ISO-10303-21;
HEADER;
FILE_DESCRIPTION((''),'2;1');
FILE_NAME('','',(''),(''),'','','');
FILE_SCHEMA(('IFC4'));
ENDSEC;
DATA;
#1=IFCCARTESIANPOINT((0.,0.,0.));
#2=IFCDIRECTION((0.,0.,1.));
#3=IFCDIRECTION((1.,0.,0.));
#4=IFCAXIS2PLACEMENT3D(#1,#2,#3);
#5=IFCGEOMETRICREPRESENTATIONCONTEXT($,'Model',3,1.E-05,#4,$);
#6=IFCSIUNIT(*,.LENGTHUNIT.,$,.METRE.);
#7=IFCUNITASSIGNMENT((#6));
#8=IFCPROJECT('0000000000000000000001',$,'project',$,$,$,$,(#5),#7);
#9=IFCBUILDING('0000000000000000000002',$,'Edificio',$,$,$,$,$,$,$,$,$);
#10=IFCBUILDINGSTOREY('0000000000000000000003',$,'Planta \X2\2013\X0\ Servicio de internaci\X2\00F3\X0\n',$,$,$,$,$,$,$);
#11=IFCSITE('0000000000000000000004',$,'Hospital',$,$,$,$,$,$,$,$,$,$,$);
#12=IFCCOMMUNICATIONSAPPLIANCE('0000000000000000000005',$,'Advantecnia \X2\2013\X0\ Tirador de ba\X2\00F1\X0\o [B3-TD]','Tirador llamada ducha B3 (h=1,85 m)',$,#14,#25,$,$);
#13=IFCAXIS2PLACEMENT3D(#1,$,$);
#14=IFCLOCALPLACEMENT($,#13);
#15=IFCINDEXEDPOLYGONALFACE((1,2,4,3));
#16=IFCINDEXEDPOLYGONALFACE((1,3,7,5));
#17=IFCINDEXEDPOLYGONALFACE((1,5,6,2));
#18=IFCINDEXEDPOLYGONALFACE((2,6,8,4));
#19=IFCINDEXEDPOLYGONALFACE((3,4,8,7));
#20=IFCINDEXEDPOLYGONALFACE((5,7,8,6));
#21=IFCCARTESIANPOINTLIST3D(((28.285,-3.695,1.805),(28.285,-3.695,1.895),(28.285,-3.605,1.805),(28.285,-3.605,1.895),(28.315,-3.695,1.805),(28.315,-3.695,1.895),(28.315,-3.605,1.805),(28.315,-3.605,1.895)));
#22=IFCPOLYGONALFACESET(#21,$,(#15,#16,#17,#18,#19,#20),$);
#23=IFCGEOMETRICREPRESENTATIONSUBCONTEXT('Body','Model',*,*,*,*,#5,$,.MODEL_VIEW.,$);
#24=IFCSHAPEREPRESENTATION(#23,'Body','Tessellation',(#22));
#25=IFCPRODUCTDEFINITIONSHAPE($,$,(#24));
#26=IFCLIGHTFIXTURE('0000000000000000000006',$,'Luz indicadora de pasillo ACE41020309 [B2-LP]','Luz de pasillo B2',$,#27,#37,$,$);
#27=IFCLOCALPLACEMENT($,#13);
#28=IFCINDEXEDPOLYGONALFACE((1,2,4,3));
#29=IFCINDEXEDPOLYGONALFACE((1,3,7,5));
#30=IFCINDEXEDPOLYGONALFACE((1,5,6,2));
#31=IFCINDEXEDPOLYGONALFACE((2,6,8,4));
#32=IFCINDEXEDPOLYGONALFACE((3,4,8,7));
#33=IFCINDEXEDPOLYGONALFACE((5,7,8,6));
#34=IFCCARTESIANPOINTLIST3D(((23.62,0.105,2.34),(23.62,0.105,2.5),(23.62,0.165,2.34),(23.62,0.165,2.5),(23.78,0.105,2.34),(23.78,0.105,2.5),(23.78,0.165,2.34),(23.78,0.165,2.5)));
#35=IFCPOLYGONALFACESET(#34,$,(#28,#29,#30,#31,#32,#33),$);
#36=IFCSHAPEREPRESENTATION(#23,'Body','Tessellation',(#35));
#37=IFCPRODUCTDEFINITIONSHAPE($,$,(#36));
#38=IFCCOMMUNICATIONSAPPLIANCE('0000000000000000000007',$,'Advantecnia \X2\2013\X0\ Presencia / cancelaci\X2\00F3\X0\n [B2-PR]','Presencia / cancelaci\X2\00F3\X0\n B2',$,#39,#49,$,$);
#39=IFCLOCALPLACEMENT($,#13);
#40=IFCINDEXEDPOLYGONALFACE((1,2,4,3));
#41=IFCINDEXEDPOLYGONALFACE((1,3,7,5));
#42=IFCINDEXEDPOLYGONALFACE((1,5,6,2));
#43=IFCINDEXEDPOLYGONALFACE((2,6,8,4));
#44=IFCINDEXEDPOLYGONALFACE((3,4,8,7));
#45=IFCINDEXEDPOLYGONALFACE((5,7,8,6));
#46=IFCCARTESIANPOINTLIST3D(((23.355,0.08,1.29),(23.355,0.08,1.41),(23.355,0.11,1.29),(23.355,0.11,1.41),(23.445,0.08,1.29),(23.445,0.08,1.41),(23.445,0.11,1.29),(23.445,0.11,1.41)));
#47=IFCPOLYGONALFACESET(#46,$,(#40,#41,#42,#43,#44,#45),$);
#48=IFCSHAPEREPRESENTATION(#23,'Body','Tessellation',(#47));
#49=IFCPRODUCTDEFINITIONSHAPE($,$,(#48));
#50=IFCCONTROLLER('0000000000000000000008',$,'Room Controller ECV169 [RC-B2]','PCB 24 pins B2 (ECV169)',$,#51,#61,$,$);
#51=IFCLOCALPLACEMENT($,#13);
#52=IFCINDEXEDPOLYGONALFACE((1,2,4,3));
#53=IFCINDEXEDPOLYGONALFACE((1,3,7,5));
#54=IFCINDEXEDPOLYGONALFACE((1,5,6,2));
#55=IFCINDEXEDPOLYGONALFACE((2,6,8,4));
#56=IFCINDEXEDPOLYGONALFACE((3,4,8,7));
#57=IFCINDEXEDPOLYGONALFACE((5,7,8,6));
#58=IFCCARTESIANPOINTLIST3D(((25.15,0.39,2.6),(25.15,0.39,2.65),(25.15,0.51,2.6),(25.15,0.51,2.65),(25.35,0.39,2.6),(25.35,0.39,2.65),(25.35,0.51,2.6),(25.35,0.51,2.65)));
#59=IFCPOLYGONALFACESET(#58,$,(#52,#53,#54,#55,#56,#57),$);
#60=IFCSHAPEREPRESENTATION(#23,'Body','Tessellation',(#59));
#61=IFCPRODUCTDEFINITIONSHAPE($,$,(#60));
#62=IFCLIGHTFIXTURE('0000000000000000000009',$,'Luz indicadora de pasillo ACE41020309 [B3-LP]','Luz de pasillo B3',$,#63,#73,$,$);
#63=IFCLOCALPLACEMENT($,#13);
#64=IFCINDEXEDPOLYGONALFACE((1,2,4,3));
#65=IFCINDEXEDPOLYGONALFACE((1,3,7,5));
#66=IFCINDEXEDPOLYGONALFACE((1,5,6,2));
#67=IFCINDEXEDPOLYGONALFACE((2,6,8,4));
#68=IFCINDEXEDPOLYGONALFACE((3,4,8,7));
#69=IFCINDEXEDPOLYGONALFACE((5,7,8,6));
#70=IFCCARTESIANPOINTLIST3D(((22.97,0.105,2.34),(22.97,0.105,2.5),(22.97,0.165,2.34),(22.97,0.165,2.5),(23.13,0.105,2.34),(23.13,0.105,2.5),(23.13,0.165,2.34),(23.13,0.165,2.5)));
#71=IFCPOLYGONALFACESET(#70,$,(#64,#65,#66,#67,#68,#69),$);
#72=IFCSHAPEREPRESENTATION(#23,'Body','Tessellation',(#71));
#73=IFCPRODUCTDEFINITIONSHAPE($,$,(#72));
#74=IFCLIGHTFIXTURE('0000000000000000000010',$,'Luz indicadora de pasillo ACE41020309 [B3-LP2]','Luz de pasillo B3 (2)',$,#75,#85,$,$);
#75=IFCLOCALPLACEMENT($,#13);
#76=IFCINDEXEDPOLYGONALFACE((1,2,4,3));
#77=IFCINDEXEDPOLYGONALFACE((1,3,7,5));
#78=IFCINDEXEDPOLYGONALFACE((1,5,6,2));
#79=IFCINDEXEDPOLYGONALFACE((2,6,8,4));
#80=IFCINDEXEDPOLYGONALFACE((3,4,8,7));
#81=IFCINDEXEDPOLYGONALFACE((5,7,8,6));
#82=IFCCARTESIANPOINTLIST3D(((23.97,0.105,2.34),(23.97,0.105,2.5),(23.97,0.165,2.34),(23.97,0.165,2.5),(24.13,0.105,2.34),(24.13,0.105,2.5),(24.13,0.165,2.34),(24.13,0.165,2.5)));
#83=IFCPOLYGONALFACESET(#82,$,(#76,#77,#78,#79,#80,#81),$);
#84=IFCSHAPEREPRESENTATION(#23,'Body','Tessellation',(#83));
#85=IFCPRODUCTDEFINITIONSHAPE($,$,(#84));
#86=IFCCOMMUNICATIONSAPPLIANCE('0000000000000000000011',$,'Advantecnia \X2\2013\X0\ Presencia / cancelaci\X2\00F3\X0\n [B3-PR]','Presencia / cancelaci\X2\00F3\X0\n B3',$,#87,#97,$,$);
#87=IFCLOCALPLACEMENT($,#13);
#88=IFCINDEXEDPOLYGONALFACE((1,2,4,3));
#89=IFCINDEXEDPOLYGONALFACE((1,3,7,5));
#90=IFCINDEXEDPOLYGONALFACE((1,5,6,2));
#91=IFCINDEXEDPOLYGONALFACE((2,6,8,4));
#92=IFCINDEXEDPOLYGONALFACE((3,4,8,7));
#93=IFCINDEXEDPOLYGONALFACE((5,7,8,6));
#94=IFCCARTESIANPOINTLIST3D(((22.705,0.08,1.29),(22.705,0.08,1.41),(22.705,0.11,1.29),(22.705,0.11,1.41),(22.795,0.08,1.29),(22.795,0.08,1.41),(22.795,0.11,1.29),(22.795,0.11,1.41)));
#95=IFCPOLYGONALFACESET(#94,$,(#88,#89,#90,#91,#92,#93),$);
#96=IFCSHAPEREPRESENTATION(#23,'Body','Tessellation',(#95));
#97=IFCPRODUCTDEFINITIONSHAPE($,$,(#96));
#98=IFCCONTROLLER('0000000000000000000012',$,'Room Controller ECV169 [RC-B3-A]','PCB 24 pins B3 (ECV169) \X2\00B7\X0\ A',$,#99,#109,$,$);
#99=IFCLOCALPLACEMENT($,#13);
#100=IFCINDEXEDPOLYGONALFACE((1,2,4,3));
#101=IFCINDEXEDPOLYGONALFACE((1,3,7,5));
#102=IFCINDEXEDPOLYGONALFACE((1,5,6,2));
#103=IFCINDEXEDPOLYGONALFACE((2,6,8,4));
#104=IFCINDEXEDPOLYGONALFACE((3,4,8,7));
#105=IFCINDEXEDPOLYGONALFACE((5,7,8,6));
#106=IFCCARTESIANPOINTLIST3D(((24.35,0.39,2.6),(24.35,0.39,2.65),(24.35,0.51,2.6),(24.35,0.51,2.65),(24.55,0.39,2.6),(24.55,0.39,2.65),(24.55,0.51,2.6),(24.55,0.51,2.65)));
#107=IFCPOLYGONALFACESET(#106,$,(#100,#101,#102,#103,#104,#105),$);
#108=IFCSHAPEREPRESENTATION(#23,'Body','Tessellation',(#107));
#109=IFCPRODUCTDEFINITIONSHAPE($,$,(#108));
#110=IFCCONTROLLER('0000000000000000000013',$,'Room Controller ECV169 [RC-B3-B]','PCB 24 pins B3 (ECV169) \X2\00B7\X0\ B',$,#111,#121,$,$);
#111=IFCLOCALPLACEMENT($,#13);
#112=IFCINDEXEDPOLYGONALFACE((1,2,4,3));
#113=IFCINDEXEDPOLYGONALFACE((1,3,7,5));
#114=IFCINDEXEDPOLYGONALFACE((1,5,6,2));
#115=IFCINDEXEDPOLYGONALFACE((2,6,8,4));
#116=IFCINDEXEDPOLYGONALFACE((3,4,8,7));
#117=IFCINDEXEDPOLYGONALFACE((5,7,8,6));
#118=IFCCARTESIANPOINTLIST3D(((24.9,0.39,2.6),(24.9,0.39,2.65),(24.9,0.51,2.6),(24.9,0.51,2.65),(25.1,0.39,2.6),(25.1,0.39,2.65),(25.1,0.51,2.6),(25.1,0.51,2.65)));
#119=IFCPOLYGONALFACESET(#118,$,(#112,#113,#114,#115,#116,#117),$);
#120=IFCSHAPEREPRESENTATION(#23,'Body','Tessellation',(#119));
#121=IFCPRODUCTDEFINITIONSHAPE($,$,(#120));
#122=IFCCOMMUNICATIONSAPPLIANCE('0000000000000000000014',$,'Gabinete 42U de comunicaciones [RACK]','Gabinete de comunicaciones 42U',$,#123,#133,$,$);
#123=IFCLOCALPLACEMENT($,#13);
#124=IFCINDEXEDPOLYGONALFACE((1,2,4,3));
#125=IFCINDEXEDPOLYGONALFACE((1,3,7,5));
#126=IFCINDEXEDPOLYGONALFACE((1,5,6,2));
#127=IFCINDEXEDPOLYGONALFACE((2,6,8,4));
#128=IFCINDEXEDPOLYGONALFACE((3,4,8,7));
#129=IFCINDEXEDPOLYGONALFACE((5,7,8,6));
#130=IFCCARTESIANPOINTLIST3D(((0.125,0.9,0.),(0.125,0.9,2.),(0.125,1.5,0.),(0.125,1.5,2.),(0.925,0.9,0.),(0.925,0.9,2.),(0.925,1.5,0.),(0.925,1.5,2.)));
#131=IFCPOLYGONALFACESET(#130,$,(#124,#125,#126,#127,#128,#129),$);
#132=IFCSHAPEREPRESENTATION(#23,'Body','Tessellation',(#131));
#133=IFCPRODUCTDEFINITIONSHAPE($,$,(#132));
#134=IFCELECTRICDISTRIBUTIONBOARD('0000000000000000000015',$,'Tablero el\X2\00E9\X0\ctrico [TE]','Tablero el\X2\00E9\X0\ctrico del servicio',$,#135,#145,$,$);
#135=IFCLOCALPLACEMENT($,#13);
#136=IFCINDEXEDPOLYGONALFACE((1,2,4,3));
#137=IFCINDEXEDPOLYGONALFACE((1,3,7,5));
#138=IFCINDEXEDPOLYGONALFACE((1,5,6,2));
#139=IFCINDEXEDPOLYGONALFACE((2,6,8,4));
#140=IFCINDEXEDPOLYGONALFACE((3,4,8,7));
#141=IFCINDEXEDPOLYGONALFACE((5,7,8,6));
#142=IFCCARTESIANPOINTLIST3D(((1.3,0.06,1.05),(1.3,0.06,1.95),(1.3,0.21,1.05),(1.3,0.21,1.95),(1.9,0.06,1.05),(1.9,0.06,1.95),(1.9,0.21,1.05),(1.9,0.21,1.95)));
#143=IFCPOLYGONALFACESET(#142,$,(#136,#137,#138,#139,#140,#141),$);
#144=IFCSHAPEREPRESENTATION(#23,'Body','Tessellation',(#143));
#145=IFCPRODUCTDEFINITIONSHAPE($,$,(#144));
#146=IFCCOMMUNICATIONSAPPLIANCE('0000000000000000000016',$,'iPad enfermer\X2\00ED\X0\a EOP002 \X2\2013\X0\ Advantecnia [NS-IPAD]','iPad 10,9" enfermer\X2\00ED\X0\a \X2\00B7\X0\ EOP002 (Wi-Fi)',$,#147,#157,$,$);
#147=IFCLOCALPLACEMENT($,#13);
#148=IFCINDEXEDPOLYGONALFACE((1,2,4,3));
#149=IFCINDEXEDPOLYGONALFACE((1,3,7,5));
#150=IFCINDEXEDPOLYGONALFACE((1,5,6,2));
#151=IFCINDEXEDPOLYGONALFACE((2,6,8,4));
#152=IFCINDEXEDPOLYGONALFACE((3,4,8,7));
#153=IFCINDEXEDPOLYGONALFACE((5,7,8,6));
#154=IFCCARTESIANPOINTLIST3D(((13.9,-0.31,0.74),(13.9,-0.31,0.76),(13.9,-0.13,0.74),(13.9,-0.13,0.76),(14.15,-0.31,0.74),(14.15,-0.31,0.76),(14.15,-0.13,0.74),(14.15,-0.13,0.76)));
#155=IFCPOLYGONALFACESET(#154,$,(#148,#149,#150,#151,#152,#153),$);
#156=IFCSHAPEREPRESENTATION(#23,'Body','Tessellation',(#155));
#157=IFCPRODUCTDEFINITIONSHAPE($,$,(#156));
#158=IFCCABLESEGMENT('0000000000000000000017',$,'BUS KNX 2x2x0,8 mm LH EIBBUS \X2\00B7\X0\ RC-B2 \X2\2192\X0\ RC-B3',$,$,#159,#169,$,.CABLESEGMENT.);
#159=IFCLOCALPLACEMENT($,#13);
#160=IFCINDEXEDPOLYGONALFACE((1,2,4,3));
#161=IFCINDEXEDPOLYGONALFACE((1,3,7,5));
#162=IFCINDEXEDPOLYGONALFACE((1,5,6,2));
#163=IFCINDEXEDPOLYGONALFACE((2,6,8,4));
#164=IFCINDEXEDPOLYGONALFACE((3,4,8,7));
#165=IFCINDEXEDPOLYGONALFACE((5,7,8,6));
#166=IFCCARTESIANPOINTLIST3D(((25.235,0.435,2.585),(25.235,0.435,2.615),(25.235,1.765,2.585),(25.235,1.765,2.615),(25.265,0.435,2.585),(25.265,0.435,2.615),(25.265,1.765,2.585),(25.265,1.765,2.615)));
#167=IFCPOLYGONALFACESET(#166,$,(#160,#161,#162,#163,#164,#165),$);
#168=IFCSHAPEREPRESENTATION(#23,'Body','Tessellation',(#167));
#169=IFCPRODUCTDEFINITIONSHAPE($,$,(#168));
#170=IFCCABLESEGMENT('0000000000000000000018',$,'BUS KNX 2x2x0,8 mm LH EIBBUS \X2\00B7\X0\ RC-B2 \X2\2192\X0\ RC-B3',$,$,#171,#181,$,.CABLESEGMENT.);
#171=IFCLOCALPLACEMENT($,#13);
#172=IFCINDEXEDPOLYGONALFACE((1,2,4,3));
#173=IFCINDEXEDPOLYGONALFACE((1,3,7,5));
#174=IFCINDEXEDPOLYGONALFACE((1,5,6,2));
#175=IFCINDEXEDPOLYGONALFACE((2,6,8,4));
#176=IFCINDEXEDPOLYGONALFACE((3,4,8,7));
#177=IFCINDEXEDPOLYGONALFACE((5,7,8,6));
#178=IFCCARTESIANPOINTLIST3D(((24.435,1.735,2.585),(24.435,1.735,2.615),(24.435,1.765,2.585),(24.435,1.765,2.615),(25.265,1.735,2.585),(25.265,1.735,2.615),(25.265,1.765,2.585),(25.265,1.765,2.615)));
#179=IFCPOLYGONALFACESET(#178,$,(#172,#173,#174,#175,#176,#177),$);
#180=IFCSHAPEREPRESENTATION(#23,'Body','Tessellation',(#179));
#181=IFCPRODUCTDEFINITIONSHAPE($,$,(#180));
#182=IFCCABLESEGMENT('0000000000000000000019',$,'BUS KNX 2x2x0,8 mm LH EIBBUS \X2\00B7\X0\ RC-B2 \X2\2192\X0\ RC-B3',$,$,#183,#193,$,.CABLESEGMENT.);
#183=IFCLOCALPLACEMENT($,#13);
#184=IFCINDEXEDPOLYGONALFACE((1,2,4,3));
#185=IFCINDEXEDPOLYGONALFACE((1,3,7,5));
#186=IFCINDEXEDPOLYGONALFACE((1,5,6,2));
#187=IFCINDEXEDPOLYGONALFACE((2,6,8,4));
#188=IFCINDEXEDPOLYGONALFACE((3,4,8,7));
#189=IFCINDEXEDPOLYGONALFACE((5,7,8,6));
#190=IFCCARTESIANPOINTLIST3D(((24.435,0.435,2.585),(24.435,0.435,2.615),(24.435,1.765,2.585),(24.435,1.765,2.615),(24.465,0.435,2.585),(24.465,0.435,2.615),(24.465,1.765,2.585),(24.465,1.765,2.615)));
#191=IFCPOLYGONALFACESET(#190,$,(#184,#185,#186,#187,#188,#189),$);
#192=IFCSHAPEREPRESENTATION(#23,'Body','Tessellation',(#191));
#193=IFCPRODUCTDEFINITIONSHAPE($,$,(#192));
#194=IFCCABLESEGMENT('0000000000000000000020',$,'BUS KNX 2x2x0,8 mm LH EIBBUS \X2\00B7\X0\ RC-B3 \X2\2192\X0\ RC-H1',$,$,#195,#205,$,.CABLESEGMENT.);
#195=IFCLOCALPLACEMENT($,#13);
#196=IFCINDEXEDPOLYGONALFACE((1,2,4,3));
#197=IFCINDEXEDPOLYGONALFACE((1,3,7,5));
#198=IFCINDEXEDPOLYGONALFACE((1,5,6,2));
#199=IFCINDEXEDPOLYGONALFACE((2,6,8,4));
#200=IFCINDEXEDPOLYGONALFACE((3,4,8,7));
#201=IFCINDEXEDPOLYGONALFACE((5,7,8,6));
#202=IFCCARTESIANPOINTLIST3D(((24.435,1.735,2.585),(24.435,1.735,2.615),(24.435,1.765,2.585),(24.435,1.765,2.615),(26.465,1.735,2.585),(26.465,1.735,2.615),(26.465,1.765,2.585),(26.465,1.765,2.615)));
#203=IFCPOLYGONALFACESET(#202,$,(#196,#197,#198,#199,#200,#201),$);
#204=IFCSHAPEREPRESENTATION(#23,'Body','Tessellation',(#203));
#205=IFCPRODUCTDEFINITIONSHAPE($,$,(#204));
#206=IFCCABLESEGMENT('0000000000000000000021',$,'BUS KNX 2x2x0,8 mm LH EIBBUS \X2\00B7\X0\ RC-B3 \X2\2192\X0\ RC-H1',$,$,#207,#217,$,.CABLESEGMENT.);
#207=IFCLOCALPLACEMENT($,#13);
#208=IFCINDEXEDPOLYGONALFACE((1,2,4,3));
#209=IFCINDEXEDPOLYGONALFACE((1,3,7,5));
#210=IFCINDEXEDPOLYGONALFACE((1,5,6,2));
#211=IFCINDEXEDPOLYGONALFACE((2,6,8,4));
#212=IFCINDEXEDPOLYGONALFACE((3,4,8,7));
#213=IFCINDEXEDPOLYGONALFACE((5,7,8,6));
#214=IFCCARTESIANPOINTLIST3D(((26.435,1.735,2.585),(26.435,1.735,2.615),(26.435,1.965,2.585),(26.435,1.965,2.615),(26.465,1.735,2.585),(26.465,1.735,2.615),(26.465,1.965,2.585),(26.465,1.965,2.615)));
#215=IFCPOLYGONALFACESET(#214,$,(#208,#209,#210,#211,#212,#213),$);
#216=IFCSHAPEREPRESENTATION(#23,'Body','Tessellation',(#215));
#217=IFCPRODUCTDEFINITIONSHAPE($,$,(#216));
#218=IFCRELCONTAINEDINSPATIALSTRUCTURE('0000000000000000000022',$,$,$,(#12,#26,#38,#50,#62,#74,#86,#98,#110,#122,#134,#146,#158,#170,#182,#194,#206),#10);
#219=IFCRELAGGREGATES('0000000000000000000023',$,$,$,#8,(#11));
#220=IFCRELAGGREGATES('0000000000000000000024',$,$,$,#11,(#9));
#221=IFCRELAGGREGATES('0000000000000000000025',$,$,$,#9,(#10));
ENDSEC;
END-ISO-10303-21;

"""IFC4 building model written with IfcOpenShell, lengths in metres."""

from ifc_helpers import new_model, si_unit, frame, origin_with_axes, context, subcontext, project, spatial, line, indexed_curve, outline, extrude, element, save


model = new_model("IFC4")

# Units and contexts
model_context = context("Model", 3, precision=1e-05, world=origin_with_axes())
body_context = subcontext(model_context, "Body", "Model", "MODEL_VIEW")
ifc_project = project(units=[si_unit("LENGTHUNIT", "METRE")], contexts=[model_context])

# Site, building, storey
site = spatial("IfcSite", under=ifc_project, Name="Hospital")
building = spatial("IfcBuilding", under=site, Name="Edificio")
storey = spatial("IfcBuildingStorey", under=building, Name="Planta – Servicio de internación")

# Communications appliance
element("IfcCommunicationsAppliance", 1, inside=storey, Name="Advantecnia – Tirador de baño [B3-TD]", Description="Tirador llamada ducha B3 (h=1,85 m)", context=body_context, shape_type="SweptSolid", body=[
    extrude(outline(indexed_curve([(0.0, 0.0), (0.03, 0.0), (0.03, 0.09), (0.0, 0.09)], segments=[line(1, 2, 3, 4, 1)])), frame((28.285, -3.695, 1.805), z_axis=(0.0, 0.0, 1.0), x_axis=(1.0, 0.0, 0.0)), (0.0, 0.0, 1.0), 0.09),
])

# Light fixture
element("IfcLightFixture", 2, inside=storey, Name="Luz indicadora de pasillo ACE41020309 [B2-LP]", Description="Luz de pasillo B2", context=body_context, shape_type="SweptSolid", body=[
    extrude(outline(indexed_curve([(0.0, 0.0), (0.16, 0.0), (0.16, 0.06), (0.0, 0.06)], segments=[line(1, 2, 3, 4, 1)])), frame((23.62, 0.105, 2.34), z_axis=(0.0, 0.0, 1.0), x_axis=(1.0, 0.0, 0.0)), (0.0, 0.0, 1.0), 0.16),
])

# Communications appliance
element("IfcCommunicationsAppliance", 3, inside=storey, Name="Advantecnia – Presencia / cancelación [B2-PR]", Description="Presencia / cancelación B2", context=body_context, shape_type="SweptSolid", body=[
    extrude(outline(indexed_curve([(0.0, 0.0), (0.09, 0.0), (0.09, 0.03), (0.0, 0.03)], segments=[line(1, 2, 3, 4, 1)])), frame((23.355, 0.08, 1.29), z_axis=(0.0, 0.0, 1.0), x_axis=(1.0, 0.0, 0.0)), (0.0, 0.0, 1.0), 0.12),
])

# Controller
element("IfcController", 4, inside=storey, Name="Room Controller ECV169 [RC-B2]", Description="PCB 24 pins B2 (ECV169)", context=body_context, shape_type="SweptSolid", body=[
    extrude(outline(indexed_curve([(0.0, 0.0), (0.2, 0.0), (0.2, 0.12), (0.0, 0.12)], segments=[line(1, 2, 3, 4, 1)])), frame((25.15, 0.39, 2.6), z_axis=(0.0, 0.0, 1.0), x_axis=(1.0, 0.0, 0.0)), (0.0, 0.0, 1.0), 0.05),
])

# Light fixtures
element("IfcLightFixture", 5, inside=storey, Name="Luz indicadora de pasillo ACE41020309 [B3-LP]", Description="Luz de pasillo B3", context=body_context, shape_type="SweptSolid", body=[
    extrude(outline(indexed_curve([(0.0, 0.0), (0.16, 0.0), (0.16, 0.06), (0.0, 0.06)], segments=[line(1, 2, 3, 4, 1)])), frame((22.97, 0.105, 2.34), z_axis=(0.0, 0.0, 1.0), x_axis=(1.0, 0.0, 0.0)), (0.0, 0.0, 1.0), 0.16),
])
element("IfcLightFixture", 6, inside=storey, Name="Luz indicadora de pasillo ACE41020309 [B3-LP2]", Description="Luz de pasillo B3 (2)", context=body_context, shape_type="SweptSolid", body=[
    extrude(outline(indexed_curve([(0.0, 0.0), (0.16, 0.0), (0.16, 0.06), (0.0, 0.06)], segments=[line(1, 2, 3, 4, 1)])), frame((23.97, 0.105, 2.34), z_axis=(0.0, 0.0, 1.0), x_axis=(1.0, 0.0, 0.0)), (0.0, 0.0, 1.0), 0.16),
])

# Communications appliance
element("IfcCommunicationsAppliance", 7, inside=storey, Name="Advantecnia – Presencia / cancelación [B3-PR]", Description="Presencia / cancelación B3", context=body_context, shape_type="SweptSolid", body=[
    extrude(outline(indexed_curve([(0.0, 0.0), (0.09, 0.0), (0.09, 0.03), (0.0, 0.03)], segments=[line(1, 2, 3, 4, 1)])), frame((22.705, 0.08, 1.29), z_axis=(0.0, 0.0, 1.0), x_axis=(1.0, 0.0, 0.0)), (0.0, 0.0, 1.0), 0.12),
])

# Controllers
element("IfcController", 8, inside=storey, Name="Room Controller ECV169 [RC-B3-A]", Description="PCB 24 pins B3 (ECV169) · A", context=body_context, shape_type="SweptSolid", body=[
    extrude(outline(indexed_curve([(0.0, 0.0), (0.2, 0.0), (0.2, 0.12), (0.0, 0.12)], segments=[line(1, 2, 3, 4, 1)])), frame((24.35, 0.39, 2.6), z_axis=(0.0, 0.0, 1.0), x_axis=(1.0, 0.0, 0.0)), (0.0, 0.0, 1.0), 0.05),
])
element("IfcController", 9, inside=storey, Name="Room Controller ECV169 [RC-B3-B]", Description="PCB 24 pins B3 (ECV169) · B", context=body_context, shape_type="SweptSolid", body=[
    extrude(outline(indexed_curve([(0.0, 0.0), (0.2, 0.0), (0.2, 0.12), (0.0, 0.12)], segments=[line(1, 2, 3, 4, 1)])), frame((24.9, 0.39, 2.6), z_axis=(0.0, 0.0, 1.0), x_axis=(1.0, 0.0, 0.0)), (0.0, 0.0, 1.0), 0.05),
])

# Communications appliance
element("IfcCommunicationsAppliance", 10, inside=storey, Name="Gabinete 42U de comunicaciones [RACK]", Description="Gabinete de comunicaciones 42U", context=body_context, shape_type="SweptSolid", body=[
    extrude(outline(indexed_curve([(0.0, 0.0), (0.8, 0.0), (0.8, 0.6), (0.0, 0.6)], segments=[line(1, 2, 3, 4, 1)])), frame((0.125, 0.9, 0.0), z_axis=(0.0, 0.0, 1.0), x_axis=(1.0, 0.0, 0.0)), (0.0, 0.0, 1.0), 2.0),
])

# Electric distribution board
element("IfcElectricDistributionBoard", 11, inside=storey, Name="Tablero eléctrico [TE]", Description="Tablero eléctrico del servicio", context=body_context, shape_type="SweptSolid", body=[
    extrude(outline(indexed_curve([(0.0, 0.0), (0.6, 0.0), (0.6, 0.15), (0.0, 0.15)], segments=[line(1, 2, 3, 4, 1)])), frame((1.3, 0.06, 1.05), z_axis=(0.0, 0.0, 1.0), x_axis=(1.0, 0.0, 0.0)), (0.0, 0.0, 1.0), 0.9),
])

# Communications appliance
element("IfcCommunicationsAppliance", 12, inside=storey, Name="iPad enfermería EOP002 – Advantecnia [NS-IPAD]", Description="iPad 10,9\" enfermería · EOP002 (Wi-Fi)", context=body_context, shape_type="SweptSolid", body=[
    extrude(outline(indexed_curve([(0.0, 0.0), (0.25, 0.0), (0.25, 0.18), (0.0, 0.18)], segments=[line(1, 2, 3, 4, 1)])), frame((13.9, -0.31, 0.74), z_axis=(0.0, 0.0, 1.0), x_axis=(1.0, 0.0, 0.0)), (0.0, 0.0, 1.0), 0.02),
])

# Cable segments
element("IfcCableSegment", 13, inside=storey, Name="BUS KNX 2x2x0,8 mm LH EIBBUS · RC-B2 → RC-B3", PredefinedType="CABLESEGMENT", context=body_context, shape_type="SweptSolid", body=[
    extrude(outline(indexed_curve([(0.0, 0.0), (0.03, 0.0), (0.03, 1.33), (0.0, 1.33)], segments=[line(1, 2, 3, 4, 1)])), frame((25.235, 0.435, 2.585), z_axis=(0.0, 0.0, 1.0), x_axis=(1.0, 0.0, 0.0)), (0.0, 0.0, 1.0), 0.03),
])
element("IfcCableSegment", 14, inside=storey, Name="BUS KNX 2x2x0,8 mm LH EIBBUS · RC-B2 → RC-B3", PredefinedType="CABLESEGMENT", context=body_context, shape_type="SweptSolid", body=[
    extrude(outline(indexed_curve([(0.0, 0.0), (0.83, 0.0), (0.83, 0.03), (0.0, 0.03)], segments=[line(1, 2, 3, 4, 1)])), frame((24.435, 1.735, 2.585), z_axis=(0.0, 0.0, 1.0), x_axis=(1.0, 0.0, 0.0)), (0.0, 0.0, 1.0), 0.03),
])
element("IfcCableSegment", 15, inside=storey, Name="BUS KNX 2x2x0,8 mm LH EIBBUS · RC-B2 → RC-B3", PredefinedType="CABLESEGMENT", context=body_context, shape_type="SweptSolid", body=[
    extrude(outline(indexed_curve([(0.0, 0.0), (0.03, 0.0), (0.03, 1.33), (0.0, 1.33)], segments=[line(1, 2, 3, 4, 1)])), frame((24.435, 0.435, 2.585), z_axis=(0.0, 0.0, 1.0), x_axis=(1.0, 0.0, 0.0)), (0.0, 0.0, 1.0), 0.03),
])
element("IfcCableSegment", 16, inside=storey, Name="BUS KNX 2x2x0,8 mm LH EIBBUS · RC-B3 → RC-H1", PredefinedType="CABLESEGMENT", context=body_context, shape_type="SweptSolid", body=[
    extrude(outline(indexed_curve([(0.0, 0.0), (2.03, 0.0), (2.03, 0.03), (0.0, 0.03)], segments=[line(1, 2, 3, 4, 1)])), frame((24.435, 1.735, 2.585), z_axis=(0.0, 0.0, 1.0), x_axis=(1.0, 0.0, 0.0)), (0.0, 0.0, 1.0), 0.03),
])
element("IfcCableSegment", 17, inside=storey, Name="BUS KNX 2x2x0,8 mm LH EIBBUS · RC-B3 → RC-H1", PredefinedType="CABLESEGMENT", context=body_context, shape_type="SweptSolid", body=[
    extrude(outline(indexed_curve([(0.0, 0.0), (0.03, 0.0), (0.03, 0.23), (0.0, 0.23)], segments=[line(1, 2, 3, 4, 1)])), frame((26.435, 1.735, 2.585), z_axis=(0.0, 0.0, 1.0), x_axis=(1.0, 0.0, 0.0)), (0.0, 0.0, 1.0), 0.03),
])

save(model, "model.ifc")
